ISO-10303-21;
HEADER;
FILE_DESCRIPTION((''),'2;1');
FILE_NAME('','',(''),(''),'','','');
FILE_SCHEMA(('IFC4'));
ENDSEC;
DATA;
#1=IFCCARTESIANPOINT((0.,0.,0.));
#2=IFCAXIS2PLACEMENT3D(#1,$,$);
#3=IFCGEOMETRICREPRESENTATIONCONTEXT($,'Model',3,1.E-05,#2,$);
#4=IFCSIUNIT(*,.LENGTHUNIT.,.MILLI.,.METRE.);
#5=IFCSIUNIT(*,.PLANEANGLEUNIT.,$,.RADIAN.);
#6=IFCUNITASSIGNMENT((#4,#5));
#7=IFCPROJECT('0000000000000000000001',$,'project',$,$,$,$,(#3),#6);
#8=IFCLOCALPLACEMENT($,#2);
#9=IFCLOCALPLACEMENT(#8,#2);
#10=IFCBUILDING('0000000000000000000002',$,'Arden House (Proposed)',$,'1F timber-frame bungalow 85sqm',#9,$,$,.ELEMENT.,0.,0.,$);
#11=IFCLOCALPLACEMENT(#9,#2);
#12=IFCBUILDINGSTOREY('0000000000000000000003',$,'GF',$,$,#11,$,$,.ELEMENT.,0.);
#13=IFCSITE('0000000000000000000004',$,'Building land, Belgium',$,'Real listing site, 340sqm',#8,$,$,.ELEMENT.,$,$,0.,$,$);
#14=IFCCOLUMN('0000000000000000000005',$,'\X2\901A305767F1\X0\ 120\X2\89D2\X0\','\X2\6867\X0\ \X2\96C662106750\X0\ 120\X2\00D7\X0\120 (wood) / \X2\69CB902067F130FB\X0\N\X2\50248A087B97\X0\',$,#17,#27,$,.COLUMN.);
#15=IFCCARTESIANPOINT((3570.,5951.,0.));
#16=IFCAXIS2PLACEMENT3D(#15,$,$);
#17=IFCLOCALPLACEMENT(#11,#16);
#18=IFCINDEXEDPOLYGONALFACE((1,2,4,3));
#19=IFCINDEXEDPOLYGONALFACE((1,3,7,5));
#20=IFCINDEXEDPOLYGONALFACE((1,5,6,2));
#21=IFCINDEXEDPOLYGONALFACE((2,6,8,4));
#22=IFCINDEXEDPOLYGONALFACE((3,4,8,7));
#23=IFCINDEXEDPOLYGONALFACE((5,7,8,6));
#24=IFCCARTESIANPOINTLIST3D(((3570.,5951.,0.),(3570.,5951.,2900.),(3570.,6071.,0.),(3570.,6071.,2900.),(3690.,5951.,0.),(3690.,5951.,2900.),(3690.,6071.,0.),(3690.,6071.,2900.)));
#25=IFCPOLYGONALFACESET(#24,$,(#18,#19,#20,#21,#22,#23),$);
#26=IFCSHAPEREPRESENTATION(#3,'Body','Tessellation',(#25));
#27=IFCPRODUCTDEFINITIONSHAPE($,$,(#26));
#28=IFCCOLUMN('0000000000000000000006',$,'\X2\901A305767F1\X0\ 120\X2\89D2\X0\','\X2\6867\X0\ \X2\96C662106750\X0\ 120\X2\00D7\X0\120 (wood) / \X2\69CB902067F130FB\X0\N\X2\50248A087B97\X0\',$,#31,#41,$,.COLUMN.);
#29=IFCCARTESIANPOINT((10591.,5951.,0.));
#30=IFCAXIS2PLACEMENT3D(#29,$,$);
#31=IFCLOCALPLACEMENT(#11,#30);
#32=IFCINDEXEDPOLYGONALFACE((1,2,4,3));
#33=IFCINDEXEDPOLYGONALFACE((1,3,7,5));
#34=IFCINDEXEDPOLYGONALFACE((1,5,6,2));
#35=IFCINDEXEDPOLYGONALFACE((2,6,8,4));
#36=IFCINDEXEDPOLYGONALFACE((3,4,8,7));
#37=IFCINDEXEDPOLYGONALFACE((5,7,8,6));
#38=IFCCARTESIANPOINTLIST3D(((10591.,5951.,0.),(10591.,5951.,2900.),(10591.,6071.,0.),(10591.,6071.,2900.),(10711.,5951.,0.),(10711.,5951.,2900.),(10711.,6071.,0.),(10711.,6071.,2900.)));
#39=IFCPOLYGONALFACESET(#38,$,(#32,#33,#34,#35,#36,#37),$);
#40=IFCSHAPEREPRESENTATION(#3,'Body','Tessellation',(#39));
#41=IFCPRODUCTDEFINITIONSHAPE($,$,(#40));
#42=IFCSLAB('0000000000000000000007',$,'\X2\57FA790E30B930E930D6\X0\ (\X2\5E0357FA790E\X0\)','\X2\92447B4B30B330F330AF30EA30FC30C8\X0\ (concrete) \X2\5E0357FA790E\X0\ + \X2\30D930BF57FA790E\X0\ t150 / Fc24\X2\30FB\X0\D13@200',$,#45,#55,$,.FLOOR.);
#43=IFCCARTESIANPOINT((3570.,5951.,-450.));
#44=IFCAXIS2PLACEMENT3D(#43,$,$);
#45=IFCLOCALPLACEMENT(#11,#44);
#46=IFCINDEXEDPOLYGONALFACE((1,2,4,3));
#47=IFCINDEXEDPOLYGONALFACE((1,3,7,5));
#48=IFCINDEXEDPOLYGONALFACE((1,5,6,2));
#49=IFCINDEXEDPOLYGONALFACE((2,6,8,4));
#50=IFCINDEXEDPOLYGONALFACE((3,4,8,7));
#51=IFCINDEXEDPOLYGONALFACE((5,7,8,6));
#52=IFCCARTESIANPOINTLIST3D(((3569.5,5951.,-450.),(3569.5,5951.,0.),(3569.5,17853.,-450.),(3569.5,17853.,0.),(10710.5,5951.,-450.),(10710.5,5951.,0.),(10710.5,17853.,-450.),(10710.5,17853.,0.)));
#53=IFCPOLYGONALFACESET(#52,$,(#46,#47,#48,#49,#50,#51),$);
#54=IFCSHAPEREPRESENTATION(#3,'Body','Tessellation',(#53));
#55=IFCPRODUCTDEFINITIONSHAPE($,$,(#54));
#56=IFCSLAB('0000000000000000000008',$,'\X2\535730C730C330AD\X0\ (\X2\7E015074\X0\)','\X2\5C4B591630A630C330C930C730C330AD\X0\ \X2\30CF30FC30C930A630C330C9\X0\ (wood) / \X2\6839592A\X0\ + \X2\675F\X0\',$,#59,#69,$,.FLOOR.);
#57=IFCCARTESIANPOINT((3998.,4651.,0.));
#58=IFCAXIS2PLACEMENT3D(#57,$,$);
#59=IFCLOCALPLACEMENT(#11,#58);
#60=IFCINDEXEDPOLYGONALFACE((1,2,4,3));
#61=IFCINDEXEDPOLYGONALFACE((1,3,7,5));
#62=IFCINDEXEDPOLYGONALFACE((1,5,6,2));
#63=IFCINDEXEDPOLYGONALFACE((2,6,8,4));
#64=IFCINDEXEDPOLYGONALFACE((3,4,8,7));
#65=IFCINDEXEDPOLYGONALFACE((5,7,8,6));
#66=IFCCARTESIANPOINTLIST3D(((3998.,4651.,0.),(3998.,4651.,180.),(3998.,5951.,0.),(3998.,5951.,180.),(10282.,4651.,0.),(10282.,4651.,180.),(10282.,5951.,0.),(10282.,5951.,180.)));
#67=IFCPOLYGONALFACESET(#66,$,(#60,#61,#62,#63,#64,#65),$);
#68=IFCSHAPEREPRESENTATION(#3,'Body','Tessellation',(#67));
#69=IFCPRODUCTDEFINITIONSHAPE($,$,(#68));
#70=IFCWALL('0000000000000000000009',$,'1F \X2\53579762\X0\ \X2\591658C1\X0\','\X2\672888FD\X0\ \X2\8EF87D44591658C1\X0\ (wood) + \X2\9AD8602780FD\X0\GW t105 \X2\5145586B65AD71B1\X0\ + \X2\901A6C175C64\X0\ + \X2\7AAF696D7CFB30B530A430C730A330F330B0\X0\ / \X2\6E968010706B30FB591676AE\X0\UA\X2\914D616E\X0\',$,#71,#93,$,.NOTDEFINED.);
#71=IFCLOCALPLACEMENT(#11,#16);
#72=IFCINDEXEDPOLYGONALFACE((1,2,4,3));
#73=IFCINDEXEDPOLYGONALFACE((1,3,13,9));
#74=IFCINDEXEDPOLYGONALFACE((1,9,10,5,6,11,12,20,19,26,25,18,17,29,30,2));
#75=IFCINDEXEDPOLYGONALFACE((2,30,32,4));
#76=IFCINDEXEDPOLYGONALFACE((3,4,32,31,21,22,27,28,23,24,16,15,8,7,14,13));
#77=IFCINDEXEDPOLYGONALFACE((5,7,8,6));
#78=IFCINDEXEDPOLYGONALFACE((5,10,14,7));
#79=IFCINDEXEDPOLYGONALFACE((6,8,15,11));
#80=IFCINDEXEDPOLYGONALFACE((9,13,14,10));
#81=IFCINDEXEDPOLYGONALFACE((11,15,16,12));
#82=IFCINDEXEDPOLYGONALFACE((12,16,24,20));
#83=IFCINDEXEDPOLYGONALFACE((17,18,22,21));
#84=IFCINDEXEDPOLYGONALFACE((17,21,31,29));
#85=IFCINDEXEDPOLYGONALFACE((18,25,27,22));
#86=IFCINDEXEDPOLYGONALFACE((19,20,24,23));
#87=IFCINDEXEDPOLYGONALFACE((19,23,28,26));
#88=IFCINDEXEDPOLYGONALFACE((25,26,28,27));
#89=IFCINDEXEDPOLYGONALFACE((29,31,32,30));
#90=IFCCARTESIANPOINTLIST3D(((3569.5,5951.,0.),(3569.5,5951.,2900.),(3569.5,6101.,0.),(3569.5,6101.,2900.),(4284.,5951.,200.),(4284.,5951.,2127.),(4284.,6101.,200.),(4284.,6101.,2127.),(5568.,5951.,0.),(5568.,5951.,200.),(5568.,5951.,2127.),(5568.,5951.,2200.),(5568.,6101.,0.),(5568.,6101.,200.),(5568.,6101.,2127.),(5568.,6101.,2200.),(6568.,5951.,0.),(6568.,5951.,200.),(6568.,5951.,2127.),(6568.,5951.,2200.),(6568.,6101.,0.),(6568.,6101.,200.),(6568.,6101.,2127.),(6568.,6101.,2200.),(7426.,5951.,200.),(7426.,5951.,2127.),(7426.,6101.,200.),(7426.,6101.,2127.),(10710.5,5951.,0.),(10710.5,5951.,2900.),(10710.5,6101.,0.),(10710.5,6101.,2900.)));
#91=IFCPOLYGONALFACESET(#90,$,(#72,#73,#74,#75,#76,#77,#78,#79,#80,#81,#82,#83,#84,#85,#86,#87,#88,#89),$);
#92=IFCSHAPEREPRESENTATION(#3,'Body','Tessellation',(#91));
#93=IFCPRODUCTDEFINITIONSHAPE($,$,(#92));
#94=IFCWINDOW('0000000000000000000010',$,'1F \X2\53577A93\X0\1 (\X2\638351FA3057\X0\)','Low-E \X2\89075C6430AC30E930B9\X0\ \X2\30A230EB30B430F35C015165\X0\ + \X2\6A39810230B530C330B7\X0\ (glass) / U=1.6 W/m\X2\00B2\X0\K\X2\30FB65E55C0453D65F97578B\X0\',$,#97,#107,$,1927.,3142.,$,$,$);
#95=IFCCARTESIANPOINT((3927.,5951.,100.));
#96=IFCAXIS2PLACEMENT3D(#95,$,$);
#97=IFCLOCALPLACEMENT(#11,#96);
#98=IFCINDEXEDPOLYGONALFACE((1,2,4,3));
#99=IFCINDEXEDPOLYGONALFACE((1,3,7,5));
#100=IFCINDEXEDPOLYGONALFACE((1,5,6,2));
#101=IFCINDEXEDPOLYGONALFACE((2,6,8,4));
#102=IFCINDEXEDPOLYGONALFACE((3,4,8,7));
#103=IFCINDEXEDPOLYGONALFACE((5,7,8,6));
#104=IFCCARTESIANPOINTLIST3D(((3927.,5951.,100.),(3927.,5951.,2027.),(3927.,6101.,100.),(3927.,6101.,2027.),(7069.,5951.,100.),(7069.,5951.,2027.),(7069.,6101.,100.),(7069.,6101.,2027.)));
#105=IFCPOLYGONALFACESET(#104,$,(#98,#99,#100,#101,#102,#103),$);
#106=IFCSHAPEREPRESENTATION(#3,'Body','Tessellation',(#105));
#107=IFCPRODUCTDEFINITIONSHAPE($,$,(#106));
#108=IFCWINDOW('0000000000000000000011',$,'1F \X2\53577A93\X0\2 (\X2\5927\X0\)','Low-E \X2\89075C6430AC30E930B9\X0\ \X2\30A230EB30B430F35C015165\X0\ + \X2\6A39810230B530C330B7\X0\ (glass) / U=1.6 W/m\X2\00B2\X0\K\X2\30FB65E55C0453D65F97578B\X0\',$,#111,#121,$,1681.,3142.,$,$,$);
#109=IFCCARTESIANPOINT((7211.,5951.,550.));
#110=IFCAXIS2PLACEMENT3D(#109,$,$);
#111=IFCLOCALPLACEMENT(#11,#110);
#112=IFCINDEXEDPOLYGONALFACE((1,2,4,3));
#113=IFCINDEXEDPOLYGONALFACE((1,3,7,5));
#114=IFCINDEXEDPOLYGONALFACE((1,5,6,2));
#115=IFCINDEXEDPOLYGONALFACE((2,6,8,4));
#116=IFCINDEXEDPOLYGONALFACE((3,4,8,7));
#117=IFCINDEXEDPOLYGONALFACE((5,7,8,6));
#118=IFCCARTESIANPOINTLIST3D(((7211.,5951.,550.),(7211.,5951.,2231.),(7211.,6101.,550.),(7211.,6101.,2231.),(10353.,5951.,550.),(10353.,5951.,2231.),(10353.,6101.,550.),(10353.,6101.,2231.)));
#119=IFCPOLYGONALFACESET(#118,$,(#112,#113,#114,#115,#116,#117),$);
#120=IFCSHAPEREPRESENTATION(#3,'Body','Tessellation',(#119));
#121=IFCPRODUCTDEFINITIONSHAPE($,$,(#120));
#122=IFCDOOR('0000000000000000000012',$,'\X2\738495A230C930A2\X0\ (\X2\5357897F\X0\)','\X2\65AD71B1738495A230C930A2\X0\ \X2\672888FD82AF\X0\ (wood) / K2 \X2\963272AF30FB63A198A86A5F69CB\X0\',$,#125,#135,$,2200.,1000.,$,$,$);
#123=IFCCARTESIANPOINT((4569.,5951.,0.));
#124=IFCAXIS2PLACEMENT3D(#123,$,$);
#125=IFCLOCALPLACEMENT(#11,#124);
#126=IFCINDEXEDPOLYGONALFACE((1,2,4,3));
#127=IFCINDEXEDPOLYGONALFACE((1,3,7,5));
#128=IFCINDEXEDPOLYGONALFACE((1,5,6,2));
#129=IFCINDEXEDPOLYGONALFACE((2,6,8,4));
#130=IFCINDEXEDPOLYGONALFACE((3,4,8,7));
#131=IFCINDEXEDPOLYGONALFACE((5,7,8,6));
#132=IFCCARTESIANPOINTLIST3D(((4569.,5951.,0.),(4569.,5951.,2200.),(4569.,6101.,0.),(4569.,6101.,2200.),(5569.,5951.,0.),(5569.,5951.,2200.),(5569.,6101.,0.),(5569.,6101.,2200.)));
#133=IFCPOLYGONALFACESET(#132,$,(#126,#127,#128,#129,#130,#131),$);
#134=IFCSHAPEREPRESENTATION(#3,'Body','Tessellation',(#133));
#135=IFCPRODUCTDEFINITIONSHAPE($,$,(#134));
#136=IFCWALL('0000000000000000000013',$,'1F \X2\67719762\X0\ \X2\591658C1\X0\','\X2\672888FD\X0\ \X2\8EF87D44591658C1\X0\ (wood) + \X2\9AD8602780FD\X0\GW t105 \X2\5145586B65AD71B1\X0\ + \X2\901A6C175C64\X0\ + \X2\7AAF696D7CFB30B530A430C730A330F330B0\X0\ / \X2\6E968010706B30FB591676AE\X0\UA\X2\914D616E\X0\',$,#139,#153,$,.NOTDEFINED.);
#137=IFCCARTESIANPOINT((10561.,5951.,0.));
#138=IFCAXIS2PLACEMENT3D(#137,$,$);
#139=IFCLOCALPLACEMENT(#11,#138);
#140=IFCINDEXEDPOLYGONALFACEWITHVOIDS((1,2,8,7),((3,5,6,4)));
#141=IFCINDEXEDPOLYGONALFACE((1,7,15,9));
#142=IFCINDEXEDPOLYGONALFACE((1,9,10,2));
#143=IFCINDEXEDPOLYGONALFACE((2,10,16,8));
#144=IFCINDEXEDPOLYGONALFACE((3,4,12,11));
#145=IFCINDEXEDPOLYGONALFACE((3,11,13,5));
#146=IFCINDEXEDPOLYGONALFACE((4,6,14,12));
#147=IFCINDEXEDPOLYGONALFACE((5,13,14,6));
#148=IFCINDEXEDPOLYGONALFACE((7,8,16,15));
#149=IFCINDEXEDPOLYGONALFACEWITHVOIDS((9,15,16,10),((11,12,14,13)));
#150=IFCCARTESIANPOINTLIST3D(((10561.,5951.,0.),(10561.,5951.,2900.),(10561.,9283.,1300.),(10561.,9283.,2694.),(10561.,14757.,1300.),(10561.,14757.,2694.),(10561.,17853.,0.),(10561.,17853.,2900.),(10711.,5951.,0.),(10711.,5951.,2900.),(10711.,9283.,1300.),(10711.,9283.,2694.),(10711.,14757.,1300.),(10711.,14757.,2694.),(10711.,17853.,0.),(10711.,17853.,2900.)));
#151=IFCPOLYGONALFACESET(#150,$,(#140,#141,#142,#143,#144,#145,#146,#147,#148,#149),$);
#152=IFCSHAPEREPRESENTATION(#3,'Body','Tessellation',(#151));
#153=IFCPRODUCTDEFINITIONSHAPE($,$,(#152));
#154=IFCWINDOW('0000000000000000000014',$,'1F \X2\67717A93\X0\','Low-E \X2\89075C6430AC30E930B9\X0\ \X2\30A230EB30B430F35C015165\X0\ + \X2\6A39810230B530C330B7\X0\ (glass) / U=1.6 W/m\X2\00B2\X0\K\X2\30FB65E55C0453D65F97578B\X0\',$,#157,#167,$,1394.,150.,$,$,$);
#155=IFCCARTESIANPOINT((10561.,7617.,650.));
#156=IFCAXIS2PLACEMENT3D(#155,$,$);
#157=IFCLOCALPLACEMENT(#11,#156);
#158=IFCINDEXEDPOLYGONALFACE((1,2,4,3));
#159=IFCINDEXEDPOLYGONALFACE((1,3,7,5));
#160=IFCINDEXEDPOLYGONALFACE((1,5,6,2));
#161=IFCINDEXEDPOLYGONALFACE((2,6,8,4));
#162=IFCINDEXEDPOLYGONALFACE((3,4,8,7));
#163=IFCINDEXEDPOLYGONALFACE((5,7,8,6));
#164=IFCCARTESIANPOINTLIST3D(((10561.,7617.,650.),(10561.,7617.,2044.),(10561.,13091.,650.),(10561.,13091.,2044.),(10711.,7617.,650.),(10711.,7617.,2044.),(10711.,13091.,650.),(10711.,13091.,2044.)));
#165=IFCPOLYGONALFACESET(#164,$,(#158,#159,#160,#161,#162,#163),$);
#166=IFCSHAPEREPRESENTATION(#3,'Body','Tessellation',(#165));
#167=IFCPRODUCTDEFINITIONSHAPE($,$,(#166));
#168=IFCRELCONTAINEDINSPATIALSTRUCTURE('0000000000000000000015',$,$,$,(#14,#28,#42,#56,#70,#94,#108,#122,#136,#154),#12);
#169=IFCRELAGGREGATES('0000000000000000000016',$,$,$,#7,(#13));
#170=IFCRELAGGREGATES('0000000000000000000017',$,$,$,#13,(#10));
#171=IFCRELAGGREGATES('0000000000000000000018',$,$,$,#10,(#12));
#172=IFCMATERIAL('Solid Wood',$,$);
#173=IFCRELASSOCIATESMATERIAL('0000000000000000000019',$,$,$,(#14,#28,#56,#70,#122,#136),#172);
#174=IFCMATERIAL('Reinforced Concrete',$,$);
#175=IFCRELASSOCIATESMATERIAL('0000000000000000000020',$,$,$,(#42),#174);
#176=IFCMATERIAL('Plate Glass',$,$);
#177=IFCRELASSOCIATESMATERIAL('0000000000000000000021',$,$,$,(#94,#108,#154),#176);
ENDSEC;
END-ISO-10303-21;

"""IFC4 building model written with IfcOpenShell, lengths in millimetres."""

from ifc_helpers import new_model, si_unit, frame, frame_2d, origin, place, context, project, spatial, rectangle, extrude, material, element, fill, save


model = new_model("IFC4")

# Units and contexts
model_context = context("Model", 3, precision=1e-05, world=origin())
ifc_project = project(units=[si_unit("LENGTHUNIT", "METRE", prefix="MILLI"), si_unit("PLANEANGLEUNIT", "RADIAN")], contexts=[model_context])

# Site, building, storey
site_placement = place(None, origin())
site = spatial("IfcSite", under=ifc_project, at=site_placement, Name="Building land, Belgium", ObjectType="Real listing site, 340sqm", CompositionType="ELEMENT", RefElevation=0.0)
building_placement = place(site_placement, origin())
building = spatial("IfcBuilding", under=site, at=building_placement, Name="Arden House (Proposed)", ObjectType="1F timber-frame bungalow 85sqm", CompositionType="ELEMENT", ElevationOfRefHeight=0.0, ElevationOfTerrain=0.0)
storey_placement = place(building_placement, origin())
storey = spatial("IfcBuildingStorey", under=building, at=storey_placement, Name="GF", CompositionType="ELEMENT", Elevation=0.0)

# Columns
ifc_material_1 = material(Name="Solid Wood")
column_1_placement = place(storey_placement, frame((3570.0, 5951.0, 0.0)))
element("IfcColumn", 1, at=column_1_placement, inside=storey, material=ifc_material_1, Name="通し柱 120角", Description="桧 集成材 120×120 (wood) / 構造柱・N値計算", PredefinedType="COLUMN", context=model_context, shape_type="SweptSolid", body=[
    extrude(rectangle(XDim=120.0, YDim=120.0, at=frame_2d((60.0, 60.0))), frame((3570.0, 5951.0, 0.0)), (0.0, 0.0, 1.0), 2900.0),
])
column_2_placement = place(storey_placement, frame((10591.0, 5951.0, 0.0)))
element("IfcColumn", 2, at=column_2_placement, inside=storey, material=ifc_material_1, Name="通し柱 120角", Description="桧 集成材 120×120 (wood) / 構造柱・N値計算", PredefinedType="COLUMN", context=model_context, shape_type="SweptSolid", body=[
    extrude(rectangle(XDim=120.0, YDim=120.0, at=frame_2d((60.0, 60.0))), frame((10591.0, 5951.0, 0.0)), (0.0, 0.0, 1.0), 2900.0),
])

# Slabs
ifc_material_2 = material(Name="Reinforced Concrete")
slab_1_placement = place(storey_placement, frame((3570.0, 5951.0, -450.0)))
element("IfcSlab", 3, at=slab_1_placement, inside=storey, material=ifc_material_2, Name="基礎スラブ (布基礎)", Description="鉄筋コンクリート (concrete) 布基礎 + ベタ基礎 t150 / Fc24・D13@200", PredefinedType="FLOOR", context=model_context, shape_type="SweptSolid", body=[
    extrude(rectangle(XDim=7141.0, YDim=11902.0, at=frame_2d((3570.0, 5951.0))), frame((3570.0, 5951.0, -450.0)), (0.0, 0.0, 1.0), 450.0),
])
slab_2_placement = place(storey_placement, frame((3998.0, 4651.0, 0.0)))
element("IfcSlab", 4, at=slab_2_placement, inside=storey, material=ifc_material_1, Name="南デッキ (縁側)", Description="屋外ウッドデッキ ハードウッド (wood) / 根太 + 束", PredefinedType="FLOOR", context=model_context, shape_type="SweptSolid", body=[
    extrude(rectangle(XDim=6284.0, YDim=1300.0, at=frame_2d((3142.0, 650.0))), frame((3998.0, 4651.0, 0.0)), (0.0, 0.0, 1.0), 180.0),
])

# Wall, openings, windows, door
wall_1_placement = place(storey_placement, frame((3570.0, 5951.0, 0.0)))
wall_1 = element("IfcWall", 5, at=wall_1_placement, inside=storey, material=ifc_material_1, Name="1F 南面 外壁", Description="木製 軸組外壁 (wood) + 高性能GW t105 充填断熱 + 通気層 + 窯業系サイディング / 準耐火・外皮UA配慮", PredefinedType="NOTDEFINED", context=model_context, shape_type="SweptSolid", body=[
    extrude(rectangle(XDim=7141.0, YDim=150.0, at=frame_2d((3570.0, 75.0))), frame((3570.0, 5951.0, 0.0)), (0.0, 0.0, 1.0), 2900.0),
])
opening_1_placement = place(storey_placement, frame((3927.0, 5951.0, 100.0)))
opening_1 = element("IfcOpeningElement", 6, at=opening_1_placement, cuts=wall_1, PredefinedType="NOTDEFINED", context=model_context, shape_type="SweptSolid", body=[
    extrude(rectangle(XDim=3142.0, YDim=150.0, at=frame_2d((1571.0, 75.0))), frame((3927.0, 5951.0, 100.0)), (0.0, 0.0, 1.0), 1927.0),
])
opening_2_placement = place(storey_placement, frame((7211.0, 5951.0, 550.0)))
opening_2 = element("IfcOpeningElement", 7, at=opening_2_placement, cuts=wall_1, PredefinedType="NOTDEFINED", context=model_context, shape_type="SweptSolid", body=[
    extrude(rectangle(XDim=3142.0, YDim=150.0, at=frame_2d((1571.0, 75.0))), frame((7211.0, 5951.0, 550.0)), (0.0, 0.0, 1.0), 1681.0),
])
opening_3_placement = place(storey_placement, frame((4569.0, 5951.0, 0.0)))
opening_3 = element("IfcOpeningElement", 8, at=opening_3_placement, cuts=wall_1, PredefinedType="NOTDEFINED", context=model_context, shape_type="SweptSolid", body=[
    extrude(rectangle(XDim=1000.0, YDim=150.0, at=frame_2d((500.0, 75.0))), frame((4569.0, 5951.0, 0.0)), (0.0, 0.0, 1.0), 2200.0),
])
ifc_material_3 = material(Name="Plate Glass")
window_1_placement = place(storey_placement, frame((3927.0, 5951.0, 100.0)))
window_1 = element("IfcWindow", 9, at=window_1_placement, inside=storey, material=ifc_material_3, Name="1F 南窓1 (掃出し)", Description="Low-E 複層ガラス アルゴン封入 + 樹脂サッシ (glass) / U=1.6 W/m²K・日射取得型", OverallHeight=1927.0, OverallWidth=3142.0, context=model_context, shape_type="SweptSolid", body=[
    extrude(rectangle(XDim=3142.0, YDim=150.0, at=frame_2d((1571.0, 75.0))), frame((3927.0, 5951.0, 100.0)), (0.0, 0.0, 1.0), 1927.0),
])
fill(opening_1, window_1)
window_2_placement = place(storey_placement, frame((7211.0, 5951.0, 550.0)))
window_2 = element("IfcWindow", 10, at=window_2_placement, inside=storey, material=ifc_material_3, Name="1F 南窓2 (大)", Description="Low-E 複層ガラス アルゴン封入 + 樹脂サッシ (glass) / U=1.6 W/m²K・日射取得型", OverallHeight=1681.0, OverallWidth=3142.0, context=model_context, shape_type="SweptSolid", body=[
    extrude(rectangle(XDim=3142.0, YDim=150.0, at=frame_2d((1571.0, 75.0))), frame((7211.0, 5951.0, 550.0)), (0.0, 0.0, 1.0), 1681.0),
])
fill(opening_2, window_2)
door_placement = place(storey_placement, frame((4569.0, 5951.0, 0.0)))
door = element("IfcDoor", 11, at=door_placement, inside=storey, material=ifc_material_1, Name="玄関ドア (南西)", Description="断熱玄関ドア 木製芯 (wood) / K2 防犯・採風機構", OverallHeight=2200.0, OverallWidth=1000.0, context=model_context, shape_type="SweptSolid", body=[
    extrude(rectangle(XDim=1000.0, YDim=150.0, at=frame_2d((500.0, 75.0))), frame((4569.0, 5951.0, 0.0)), (0.0, 0.0, 1.0), 2200.0),
])
fill(opening_3, door)

# Wall, opening, window
wall_2_placement = place(storey_placement, frame((10561.0, 5951.0, 0.0)))
wall_2 = element("IfcWall", 12, at=wall_2_placement, inside=storey, material=ifc_material_1, Name="1F 東面 外壁", Description="木製 軸組外壁 (wood) + 高性能GW t105 充填断熱 + 通気層 + 窯業系サイディング / 準耐火・外皮UA配慮", PredefinedType="NOTDEFINED", context=model_context, shape_type="SweptSolid", body=[
    extrude(rectangle(XDim=150.0, YDim=11902.0, at=frame_2d((75.0, 5951.0))), frame((10561.0, 5951.0, 0.0)), (0.0, 0.0, 1.0), 2900.0),
])
opening_4_placement = place(storey_placement, frame((10561.0, 7617.0, 650.0)))
opening_4 = element("IfcOpeningElement", 13, at=opening_4_placement, cuts=wall_2, PredefinedType="NOTDEFINED", context=model_context, shape_type="SweptSolid", body=[
    extrude(rectangle(XDim=150.0, YDim=5474.0, at=frame_2d((75.0, 2737.0))), frame((10561.0, 7617.0, 650.0)), (0.0, 0.0, 1.0), 1394.0),
])
window_3_placement = place(storey_placement, frame((10561.0, 7617.0, 650.0)))
window_3 = element("IfcWindow", 14, at=window_3_placement, inside=storey, material=ifc_material_3, Name="1F 東窓", Description="Low-E 複層ガラス アルゴン封入 + 樹脂サッシ (glass) / U=1.6 W/m²K・日射取得型", OverallHeight=1394.0, OverallWidth=150.0, context=model_context, shape_type="SweptSolid", body=[
    extrude(rectangle(XDim=150.0, YDim=5474.0, at=frame_2d((75.0, 2737.0))), frame((10561.0, 7617.0, 650.0)), (0.0, 0.0, 1.0), 1394.0),
])
fill(opening_4, window_3)

save(model, "model.ifc")
